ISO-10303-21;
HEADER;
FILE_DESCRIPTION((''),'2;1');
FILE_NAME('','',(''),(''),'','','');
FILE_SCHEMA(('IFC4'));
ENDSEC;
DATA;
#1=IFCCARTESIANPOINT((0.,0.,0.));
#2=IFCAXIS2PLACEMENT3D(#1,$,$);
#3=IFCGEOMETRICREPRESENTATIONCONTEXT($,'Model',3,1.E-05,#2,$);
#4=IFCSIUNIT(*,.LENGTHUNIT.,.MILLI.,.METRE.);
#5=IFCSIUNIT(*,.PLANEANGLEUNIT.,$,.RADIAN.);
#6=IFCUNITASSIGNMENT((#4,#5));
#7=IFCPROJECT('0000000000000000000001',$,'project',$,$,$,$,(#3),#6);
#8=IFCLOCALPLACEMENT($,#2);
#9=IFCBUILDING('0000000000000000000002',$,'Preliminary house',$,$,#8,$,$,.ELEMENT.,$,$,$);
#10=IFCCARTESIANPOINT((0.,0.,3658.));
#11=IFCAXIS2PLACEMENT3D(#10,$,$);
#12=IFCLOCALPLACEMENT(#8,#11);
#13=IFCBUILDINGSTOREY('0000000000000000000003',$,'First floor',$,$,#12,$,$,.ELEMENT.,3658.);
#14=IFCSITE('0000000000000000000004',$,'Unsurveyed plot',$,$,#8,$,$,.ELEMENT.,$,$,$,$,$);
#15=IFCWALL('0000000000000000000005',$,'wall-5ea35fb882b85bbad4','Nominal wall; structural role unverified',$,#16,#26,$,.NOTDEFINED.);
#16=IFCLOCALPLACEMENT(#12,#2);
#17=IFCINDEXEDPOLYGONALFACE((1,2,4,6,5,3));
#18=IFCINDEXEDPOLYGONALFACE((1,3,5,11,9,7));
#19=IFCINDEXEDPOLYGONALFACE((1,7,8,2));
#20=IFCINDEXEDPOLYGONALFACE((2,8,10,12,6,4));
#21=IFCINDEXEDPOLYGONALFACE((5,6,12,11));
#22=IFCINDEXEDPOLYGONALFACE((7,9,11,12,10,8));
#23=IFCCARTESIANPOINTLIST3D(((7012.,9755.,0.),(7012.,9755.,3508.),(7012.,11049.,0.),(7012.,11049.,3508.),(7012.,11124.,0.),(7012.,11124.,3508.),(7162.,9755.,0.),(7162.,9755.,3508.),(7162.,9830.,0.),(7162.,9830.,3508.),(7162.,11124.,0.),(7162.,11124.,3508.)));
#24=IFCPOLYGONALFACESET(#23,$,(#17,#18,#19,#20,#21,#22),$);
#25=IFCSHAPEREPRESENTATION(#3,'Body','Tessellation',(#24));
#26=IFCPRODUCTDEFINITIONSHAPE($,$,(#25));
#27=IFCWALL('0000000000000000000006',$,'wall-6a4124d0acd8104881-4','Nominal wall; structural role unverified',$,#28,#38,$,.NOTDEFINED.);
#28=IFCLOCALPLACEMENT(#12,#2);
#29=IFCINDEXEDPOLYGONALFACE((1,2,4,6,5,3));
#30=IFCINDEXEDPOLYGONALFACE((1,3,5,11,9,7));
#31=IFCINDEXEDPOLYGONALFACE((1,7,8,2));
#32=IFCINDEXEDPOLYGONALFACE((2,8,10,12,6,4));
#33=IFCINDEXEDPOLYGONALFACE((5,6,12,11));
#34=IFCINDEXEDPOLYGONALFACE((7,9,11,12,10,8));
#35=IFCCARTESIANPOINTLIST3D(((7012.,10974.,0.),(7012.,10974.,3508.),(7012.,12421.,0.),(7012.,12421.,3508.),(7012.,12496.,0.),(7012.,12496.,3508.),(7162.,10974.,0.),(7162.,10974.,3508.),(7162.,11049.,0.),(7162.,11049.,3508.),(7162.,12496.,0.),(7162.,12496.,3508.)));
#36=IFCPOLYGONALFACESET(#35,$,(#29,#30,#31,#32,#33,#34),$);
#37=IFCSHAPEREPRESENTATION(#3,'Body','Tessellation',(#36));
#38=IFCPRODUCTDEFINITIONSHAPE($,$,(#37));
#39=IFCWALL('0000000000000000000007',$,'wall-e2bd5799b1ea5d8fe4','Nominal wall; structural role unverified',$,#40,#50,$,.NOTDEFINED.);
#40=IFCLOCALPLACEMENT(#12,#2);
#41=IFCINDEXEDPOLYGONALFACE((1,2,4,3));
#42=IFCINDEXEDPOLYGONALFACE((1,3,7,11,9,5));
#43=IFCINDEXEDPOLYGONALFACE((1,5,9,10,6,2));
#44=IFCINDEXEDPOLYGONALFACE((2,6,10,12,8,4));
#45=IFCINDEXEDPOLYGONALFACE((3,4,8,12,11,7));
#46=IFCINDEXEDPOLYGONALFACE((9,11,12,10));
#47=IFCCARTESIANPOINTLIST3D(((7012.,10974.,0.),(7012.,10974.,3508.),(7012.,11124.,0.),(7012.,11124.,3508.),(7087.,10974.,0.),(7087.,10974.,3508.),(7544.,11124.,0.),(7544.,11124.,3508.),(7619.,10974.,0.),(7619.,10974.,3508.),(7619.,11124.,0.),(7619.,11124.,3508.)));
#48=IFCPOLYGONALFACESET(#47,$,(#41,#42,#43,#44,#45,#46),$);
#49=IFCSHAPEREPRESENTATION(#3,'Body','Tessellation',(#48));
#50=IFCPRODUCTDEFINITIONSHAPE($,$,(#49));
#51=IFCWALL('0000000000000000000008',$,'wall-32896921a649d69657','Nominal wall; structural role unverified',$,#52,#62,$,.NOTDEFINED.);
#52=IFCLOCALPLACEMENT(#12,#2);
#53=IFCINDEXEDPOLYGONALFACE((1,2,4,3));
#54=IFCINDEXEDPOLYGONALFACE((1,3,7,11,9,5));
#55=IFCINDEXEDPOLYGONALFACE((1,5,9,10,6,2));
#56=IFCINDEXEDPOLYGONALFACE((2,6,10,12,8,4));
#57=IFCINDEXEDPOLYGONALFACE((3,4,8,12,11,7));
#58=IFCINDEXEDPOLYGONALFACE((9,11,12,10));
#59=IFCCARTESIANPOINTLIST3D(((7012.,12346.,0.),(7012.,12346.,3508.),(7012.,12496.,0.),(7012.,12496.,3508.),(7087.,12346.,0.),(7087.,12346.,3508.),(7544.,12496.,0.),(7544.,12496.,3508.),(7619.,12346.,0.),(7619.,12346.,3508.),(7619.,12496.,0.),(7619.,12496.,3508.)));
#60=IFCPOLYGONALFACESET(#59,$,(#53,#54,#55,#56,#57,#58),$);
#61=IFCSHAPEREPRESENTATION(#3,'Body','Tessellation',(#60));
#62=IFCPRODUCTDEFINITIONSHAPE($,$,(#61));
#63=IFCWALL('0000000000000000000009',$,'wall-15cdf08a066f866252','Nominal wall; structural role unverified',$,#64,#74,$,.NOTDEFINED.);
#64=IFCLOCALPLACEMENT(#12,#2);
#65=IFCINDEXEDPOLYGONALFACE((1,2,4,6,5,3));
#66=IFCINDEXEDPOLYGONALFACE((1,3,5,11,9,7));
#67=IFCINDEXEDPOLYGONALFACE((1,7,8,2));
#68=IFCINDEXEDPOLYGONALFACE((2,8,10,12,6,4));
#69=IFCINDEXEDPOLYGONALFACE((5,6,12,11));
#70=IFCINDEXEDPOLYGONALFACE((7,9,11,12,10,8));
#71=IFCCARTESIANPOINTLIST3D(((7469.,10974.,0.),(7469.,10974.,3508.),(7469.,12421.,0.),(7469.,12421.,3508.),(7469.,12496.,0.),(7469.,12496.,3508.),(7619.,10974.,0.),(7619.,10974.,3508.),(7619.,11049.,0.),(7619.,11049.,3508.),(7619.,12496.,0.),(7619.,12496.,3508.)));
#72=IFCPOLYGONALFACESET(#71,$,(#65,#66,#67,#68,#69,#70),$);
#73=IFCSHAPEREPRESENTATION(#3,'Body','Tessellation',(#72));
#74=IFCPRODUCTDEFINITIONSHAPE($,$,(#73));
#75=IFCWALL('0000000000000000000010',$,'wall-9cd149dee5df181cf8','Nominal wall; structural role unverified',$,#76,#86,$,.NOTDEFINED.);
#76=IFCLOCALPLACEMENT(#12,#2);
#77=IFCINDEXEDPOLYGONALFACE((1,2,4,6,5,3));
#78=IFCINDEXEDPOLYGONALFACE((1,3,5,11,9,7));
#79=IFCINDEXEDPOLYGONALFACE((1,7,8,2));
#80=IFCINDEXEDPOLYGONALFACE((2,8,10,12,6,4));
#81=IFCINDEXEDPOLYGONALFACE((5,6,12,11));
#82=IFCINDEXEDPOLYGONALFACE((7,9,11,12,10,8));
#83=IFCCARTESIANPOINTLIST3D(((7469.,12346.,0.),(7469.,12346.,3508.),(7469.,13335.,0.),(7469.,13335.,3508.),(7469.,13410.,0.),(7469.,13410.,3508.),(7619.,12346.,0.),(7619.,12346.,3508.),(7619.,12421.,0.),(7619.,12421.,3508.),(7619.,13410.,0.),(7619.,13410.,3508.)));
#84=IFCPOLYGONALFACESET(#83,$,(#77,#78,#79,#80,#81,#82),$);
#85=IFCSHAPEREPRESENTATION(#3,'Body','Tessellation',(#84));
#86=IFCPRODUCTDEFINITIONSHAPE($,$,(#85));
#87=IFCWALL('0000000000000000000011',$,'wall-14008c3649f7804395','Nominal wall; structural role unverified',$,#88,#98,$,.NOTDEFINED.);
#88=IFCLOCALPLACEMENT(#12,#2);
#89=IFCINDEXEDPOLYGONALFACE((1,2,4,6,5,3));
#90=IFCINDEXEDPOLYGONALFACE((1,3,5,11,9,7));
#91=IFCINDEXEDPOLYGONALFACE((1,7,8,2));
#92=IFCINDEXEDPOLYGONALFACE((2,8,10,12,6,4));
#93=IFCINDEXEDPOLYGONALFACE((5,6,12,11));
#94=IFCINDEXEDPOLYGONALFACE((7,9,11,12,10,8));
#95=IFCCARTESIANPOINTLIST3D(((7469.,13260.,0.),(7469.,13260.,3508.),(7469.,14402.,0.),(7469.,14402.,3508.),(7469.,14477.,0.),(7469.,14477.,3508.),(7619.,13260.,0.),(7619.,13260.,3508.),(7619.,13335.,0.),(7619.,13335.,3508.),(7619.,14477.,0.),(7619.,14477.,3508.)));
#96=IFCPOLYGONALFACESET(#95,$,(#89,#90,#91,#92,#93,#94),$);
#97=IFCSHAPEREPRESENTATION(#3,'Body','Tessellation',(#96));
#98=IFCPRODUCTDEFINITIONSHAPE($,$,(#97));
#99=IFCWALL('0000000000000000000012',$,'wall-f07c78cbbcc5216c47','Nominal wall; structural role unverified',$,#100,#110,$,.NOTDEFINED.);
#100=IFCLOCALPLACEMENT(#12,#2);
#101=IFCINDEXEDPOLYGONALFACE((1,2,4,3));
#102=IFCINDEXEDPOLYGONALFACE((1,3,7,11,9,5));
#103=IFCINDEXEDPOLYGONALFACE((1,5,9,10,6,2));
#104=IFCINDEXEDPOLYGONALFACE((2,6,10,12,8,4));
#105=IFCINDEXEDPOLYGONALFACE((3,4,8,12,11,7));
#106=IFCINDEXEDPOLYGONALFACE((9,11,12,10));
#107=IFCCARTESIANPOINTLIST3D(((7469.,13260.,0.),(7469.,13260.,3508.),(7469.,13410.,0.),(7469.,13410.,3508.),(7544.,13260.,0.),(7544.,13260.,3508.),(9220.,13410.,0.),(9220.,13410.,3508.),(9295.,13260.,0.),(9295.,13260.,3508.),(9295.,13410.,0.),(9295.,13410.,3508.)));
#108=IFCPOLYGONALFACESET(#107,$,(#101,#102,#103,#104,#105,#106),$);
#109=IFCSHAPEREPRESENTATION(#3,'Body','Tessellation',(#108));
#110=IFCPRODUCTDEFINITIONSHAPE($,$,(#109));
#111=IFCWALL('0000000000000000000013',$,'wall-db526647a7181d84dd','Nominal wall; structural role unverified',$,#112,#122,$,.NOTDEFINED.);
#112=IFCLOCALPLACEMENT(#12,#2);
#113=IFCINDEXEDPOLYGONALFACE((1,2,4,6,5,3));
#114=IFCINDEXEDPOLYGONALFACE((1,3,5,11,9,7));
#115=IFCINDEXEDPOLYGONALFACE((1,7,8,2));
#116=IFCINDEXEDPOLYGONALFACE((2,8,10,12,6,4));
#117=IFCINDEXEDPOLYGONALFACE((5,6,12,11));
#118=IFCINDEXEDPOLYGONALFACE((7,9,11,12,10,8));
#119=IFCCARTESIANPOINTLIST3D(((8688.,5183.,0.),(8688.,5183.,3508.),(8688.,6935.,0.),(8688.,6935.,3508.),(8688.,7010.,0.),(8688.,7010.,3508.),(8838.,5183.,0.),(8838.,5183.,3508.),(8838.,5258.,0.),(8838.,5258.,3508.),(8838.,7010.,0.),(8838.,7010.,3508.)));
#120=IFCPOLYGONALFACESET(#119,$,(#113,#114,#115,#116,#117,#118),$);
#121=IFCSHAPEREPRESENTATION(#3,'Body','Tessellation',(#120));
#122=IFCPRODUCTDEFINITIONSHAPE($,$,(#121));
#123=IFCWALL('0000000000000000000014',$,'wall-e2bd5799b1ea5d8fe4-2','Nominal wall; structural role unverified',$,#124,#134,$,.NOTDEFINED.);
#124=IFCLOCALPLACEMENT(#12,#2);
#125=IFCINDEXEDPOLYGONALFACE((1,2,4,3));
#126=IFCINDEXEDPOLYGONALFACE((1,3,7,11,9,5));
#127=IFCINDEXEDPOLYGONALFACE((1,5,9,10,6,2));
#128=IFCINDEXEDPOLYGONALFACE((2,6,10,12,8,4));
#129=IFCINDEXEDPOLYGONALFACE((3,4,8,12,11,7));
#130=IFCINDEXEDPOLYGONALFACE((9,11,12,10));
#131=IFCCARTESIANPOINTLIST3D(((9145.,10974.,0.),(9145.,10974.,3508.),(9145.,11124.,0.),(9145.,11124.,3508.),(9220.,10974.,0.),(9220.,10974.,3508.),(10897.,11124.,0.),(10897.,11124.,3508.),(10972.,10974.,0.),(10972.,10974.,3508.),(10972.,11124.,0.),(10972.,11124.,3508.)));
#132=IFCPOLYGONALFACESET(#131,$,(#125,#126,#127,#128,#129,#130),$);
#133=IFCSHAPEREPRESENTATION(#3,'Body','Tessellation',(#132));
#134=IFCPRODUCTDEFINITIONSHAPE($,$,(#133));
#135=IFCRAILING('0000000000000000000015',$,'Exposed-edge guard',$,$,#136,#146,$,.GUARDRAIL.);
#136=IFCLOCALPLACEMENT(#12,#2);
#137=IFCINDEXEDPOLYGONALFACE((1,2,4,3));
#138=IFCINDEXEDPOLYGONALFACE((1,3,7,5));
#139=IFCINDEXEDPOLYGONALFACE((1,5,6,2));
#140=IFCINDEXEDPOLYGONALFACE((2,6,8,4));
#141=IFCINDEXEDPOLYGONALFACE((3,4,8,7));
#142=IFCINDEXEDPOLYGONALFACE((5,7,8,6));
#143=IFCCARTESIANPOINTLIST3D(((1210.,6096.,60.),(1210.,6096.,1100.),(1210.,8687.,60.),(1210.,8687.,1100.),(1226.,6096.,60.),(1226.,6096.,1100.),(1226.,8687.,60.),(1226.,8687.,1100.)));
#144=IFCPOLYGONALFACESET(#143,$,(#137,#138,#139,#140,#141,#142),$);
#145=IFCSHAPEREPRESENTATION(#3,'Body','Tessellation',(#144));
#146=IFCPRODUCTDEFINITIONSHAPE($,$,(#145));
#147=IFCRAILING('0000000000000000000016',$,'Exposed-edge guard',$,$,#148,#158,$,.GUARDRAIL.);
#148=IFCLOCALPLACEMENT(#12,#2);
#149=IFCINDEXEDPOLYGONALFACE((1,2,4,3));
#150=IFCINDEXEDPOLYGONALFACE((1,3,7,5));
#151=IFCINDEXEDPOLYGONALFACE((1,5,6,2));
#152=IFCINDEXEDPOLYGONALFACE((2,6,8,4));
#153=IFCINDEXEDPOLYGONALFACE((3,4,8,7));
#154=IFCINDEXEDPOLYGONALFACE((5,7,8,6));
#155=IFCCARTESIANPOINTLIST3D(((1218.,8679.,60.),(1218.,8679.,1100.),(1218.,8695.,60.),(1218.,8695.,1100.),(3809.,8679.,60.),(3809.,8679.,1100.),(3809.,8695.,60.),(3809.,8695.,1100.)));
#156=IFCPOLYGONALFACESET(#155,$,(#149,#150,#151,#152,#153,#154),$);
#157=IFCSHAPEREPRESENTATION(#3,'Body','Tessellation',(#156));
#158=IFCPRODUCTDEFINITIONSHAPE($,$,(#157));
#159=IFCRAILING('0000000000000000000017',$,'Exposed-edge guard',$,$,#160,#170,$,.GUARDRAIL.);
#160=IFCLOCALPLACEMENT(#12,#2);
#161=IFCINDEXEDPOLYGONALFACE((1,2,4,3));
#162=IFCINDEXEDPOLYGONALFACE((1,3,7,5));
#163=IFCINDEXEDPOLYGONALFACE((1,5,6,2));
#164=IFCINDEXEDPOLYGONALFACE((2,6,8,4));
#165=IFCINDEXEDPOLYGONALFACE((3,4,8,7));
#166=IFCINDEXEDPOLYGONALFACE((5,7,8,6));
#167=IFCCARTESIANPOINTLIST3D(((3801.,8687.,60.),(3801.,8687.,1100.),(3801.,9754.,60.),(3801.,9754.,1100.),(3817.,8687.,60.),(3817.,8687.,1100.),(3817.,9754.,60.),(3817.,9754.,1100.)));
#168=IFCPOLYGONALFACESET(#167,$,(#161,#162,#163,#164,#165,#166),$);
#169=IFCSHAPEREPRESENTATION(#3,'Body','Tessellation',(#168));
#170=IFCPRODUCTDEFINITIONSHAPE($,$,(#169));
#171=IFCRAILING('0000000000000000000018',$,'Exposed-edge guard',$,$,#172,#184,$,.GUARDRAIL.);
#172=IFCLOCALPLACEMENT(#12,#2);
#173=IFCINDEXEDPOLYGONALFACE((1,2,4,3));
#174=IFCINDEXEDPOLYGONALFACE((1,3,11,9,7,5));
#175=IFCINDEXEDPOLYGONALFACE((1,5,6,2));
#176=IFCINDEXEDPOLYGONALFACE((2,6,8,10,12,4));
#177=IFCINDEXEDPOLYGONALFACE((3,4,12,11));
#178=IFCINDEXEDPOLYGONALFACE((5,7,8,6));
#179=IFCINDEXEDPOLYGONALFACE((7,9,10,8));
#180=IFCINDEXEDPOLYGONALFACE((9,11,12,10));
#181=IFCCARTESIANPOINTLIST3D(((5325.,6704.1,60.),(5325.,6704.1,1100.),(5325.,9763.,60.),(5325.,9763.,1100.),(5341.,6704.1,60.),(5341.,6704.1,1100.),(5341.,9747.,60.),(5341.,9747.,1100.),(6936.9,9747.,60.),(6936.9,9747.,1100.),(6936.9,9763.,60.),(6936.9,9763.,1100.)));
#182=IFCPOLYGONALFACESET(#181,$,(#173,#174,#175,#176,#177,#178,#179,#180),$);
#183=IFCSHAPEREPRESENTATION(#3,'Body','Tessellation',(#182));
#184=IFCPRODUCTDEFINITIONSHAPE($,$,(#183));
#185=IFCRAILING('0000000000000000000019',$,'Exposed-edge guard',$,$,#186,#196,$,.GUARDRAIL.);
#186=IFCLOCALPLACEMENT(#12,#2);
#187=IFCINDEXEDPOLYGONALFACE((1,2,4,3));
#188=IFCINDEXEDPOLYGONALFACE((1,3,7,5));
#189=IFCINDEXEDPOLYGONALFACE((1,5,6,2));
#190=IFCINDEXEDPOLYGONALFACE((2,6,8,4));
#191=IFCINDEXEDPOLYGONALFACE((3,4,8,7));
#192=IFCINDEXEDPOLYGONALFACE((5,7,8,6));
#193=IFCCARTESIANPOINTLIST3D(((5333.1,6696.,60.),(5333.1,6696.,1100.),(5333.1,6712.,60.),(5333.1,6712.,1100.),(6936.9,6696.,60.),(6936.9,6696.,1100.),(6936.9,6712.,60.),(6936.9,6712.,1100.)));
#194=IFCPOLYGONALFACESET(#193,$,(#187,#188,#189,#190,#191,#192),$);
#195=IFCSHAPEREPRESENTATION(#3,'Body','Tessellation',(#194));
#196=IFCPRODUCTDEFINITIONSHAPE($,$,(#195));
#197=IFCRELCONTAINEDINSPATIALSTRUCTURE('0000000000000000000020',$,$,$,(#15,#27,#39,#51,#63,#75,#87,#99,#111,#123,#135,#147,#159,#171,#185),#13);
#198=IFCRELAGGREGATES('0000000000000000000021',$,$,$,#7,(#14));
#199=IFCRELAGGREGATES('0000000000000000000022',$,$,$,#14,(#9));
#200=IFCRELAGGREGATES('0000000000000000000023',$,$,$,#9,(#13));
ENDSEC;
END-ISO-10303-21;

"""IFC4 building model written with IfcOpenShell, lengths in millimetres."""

from ifc_helpers import new_model, si_unit, frame, origin, place, context, project, spatial, polyline, outline, extrude, element, save


model = new_model("IFC4")

# Units and contexts
model_context = context("Model", 3, precision=1e-05, world=origin())
ifc_project = project(units=[si_unit("LENGTHUNIT", "METRE", prefix="MILLI"), si_unit("PLANEANGLEUNIT", "RADIAN")], contexts=[model_context])

# Site, building, storey
placement_1 = place(None, origin())
site = spatial("IfcSite", under=ifc_project, at=placement_1, Name="Unsurveyed plot", CompositionType="ELEMENT")
building = spatial("IfcBuilding", under=site, at=placement_1, Name="Preliminary house", CompositionType="ELEMENT")
placement_2 = place(placement_1, frame((0.0, 0.0, 3658.0)))
storey = spatial("IfcBuildingStorey", under=building, at=placement_2, Name="First floor", CompositionType="ELEMENT", Elevation=3658.0)

# Walls
element("IfcWall", 1, at=placement_2, inside=storey, Name="wall-5ea35fb882b85bbad4", Description="Nominal wall; structural role unverified", PredefinedType="NOTDEFINED", context=model_context, shape_type="SweptSolid", body=[
    extrude(outline(polyline([(7012.0, 11049.0), (7012.0, 11124.0), (7162.0, 11124.0), (7162.0, 9830.0), (7162.0, 9755.0), (7012.0, 9755.0), (7012.0, 11049.0)])), origin(), (0.0, 0.0, 1.0), 3508.0),
])
element("IfcWall", 2, at=placement_2, inside=storey, Name="wall-6a4124d0acd8104881-4", Description="Nominal wall; structural role unverified", PredefinedType="NOTDEFINED", context=model_context, shape_type="SweptSolid", body=[
    extrude(outline(polyline([(7012.0, 12421.0), (7012.0, 12496.0), (7162.0, 12496.0), (7162.0, 11049.0), (7162.0, 10974.0), (7012.0, 10974.0), (7012.0, 12421.0)])), origin(), (0.0, 0.0, 1.0), 3508.0),
])
element("IfcWall", 3, at=placement_2, inside=storey, Name="wall-e2bd5799b1ea5d8fe4", Description="Nominal wall; structural role unverified", PredefinedType="NOTDEFINED", context=model_context, shape_type="SweptSolid", body=[
    extrude(outline(polyline([(7544.0, 11124.0), (7619.0, 11124.0), (7619.0, 10974.0), (7087.0, 10974.0), (7012.0, 10974.0), (7012.0, 11124.0), (7544.0, 11124.0)])), origin(), (0.0, 0.0, 1.0), 3508.0),
])
element("IfcWall", 4, at=placement_2, inside=storey, Name="wall-32896921a649d69657", Description="Nominal wall; structural role unverified", PredefinedType="NOTDEFINED", context=model_context, shape_type="SweptSolid", body=[
    extrude(outline(polyline([(7544.0, 12496.0), (7619.0, 12496.0), (7619.0, 12346.0), (7087.0, 12346.0), (7012.0, 12346.0), (7012.0, 12496.0), (7544.0, 12496.0)])), origin(), (0.0, 0.0, 1.0), 3508.0),
])
element("IfcWall", 5, at=placement_2, inside=storey, Name="wall-15cdf08a066f866252", Description="Nominal wall; structural role unverified", PredefinedType="NOTDEFINED", context=model_context, shape_type="SweptSolid", body=[
    extrude(outline(polyline([(7469.0, 12421.0), (7469.0, 12496.0), (7619.0, 12496.0), (7619.0, 11049.0), (7619.0, 10974.0), (7469.0, 10974.0), (7469.0, 12421.0)])), origin(), (0.0, 0.0, 1.0), 3508.0),
])

# Walls
element("IfcWall", 6, at=placement_2, inside=storey, Name="wall-9cd149dee5df181cf8", Description="Nominal wall; structural role unverified", PredefinedType="NOTDEFINED", context=model_context, shape_type="SweptSolid", body=[
    extrude(outline(polyline([(7469.0, 13335.0), (7469.0, 13410.0), (7619.0, 13410.0), (7619.0, 12421.0), (7619.0, 12346.0), (7469.0, 12346.0), (7469.0, 13335.0)])), origin(), (0.0, 0.0, 1.0), 3508.0),
])
element("IfcWall", 7, at=placement_2, inside=storey, Name="wall-14008c3649f7804395", Description="Nominal wall; structural role unverified", PredefinedType="NOTDEFINED", context=model_context, shape_type="SweptSolid", body=[
    extrude(outline(polyline([(7469.0, 14402.0), (7469.0, 14477.0), (7619.0, 14477.0), (7619.0, 13335.0), (7619.0, 13260.0), (7469.0, 13260.0), (7469.0, 14402.0)])), origin(), (0.0, 0.0, 1.0), 3508.0),
])
element("IfcWall", 8, at=placement_2, inside=storey, Name="wall-f07c78cbbcc5216c47", Description="Nominal wall; structural role unverified", PredefinedType="NOTDEFINED", context=model_context, shape_type="SweptSolid", body=[
    extrude(outline(polyline([(9220.0, 13410.0), (9295.0, 13410.0), (9295.0, 13260.0), (7544.0, 13260.0), (7469.0, 13260.0), (7469.0, 13410.0), (9220.0, 13410.0)])), origin(), (0.0, 0.0, 1.0), 3508.0),
])
element("IfcWall", 9, at=placement_2, inside=storey, Name="wall-db526647a7181d84dd", Description="Nominal wall; structural role unverified", PredefinedType="NOTDEFINED", context=model_context, shape_type="SweptSolid", body=[
    extrude(outline(polyline([(8688.0, 6935.0), (8688.0, 7010.0), (8838.0, 7010.0), (8838.0, 5258.0), (8838.0, 5183.0), (8688.0, 5183.0), (8688.0, 6935.0)])), origin(), (0.0, 0.0, 1.0), 3508.0),
])

# Wall
element("IfcWall", 10, at=placement_2, inside=storey, Name="wall-e2bd5799b1ea5d8fe4-2", Description="Nominal wall; structural role unverified", PredefinedType="NOTDEFINED", context=model_context, shape_type="SweptSolid", body=[
    extrude(outline(polyline([(10897.0, 11124.0), (10972.0, 11124.0), (10972.0, 10974.0), (9220.0, 10974.0), (9145.0, 10974.0), (9145.0, 11124.0), (10897.0, 11124.0)])), origin(), (0.0, 0.0, 1.0), 3508.0),
])

# Railings
element("IfcRailing", 11, at=placement_2, inside=storey, Name="Exposed-edge guard", PredefinedType="GUARDRAIL", context=model_context, shape_type="SweptSolid", body=[
    extrude(outline(polyline([(1210.0, 8687.0), (1226.0, 8687.0), (1226.0, 6096.0), (1210.0, 6096.0), (1210.0, 8687.0)])), frame((0.0, 0.0, 60.0)), (0.0, 0.0, 1.0), 1040.0),
])
element("IfcRailing", 12, at=placement_2, inside=storey, Name="Exposed-edge guard", PredefinedType="GUARDRAIL", context=model_context, shape_type="SweptSolid", body=[
    extrude(outline(polyline([(3809.0, 8695.0), (3809.0, 8679.0), (1218.0, 8679.0), (1218.0, 8695.0), (3809.0, 8695.0)])), frame((0.0, 0.0, 60.0)), (0.0, 0.0, 1.0), 1040.0),
])
element("IfcRailing", 13, at=placement_2, inside=storey, Name="Exposed-edge guard", PredefinedType="GUARDRAIL", context=model_context, shape_type="SweptSolid", body=[
    extrude(outline(polyline([(3801.0, 9754.0), (3817.0, 9754.0), (3817.0, 8687.0), (3801.0, 8687.0), (3801.0, 9754.0)])), frame((0.0, 0.0, 60.0)), (0.0, 0.0, 1.0), 1040.0),
])
element("IfcRailing", 14, at=placement_2, inside=storey, Name="Exposed-edge guard", PredefinedType="GUARDRAIL", context=model_context, shape_type="SweptSolid", body=[
    extrude(outline(polyline([(5341.0, 9747.0), (5341.0, 6704.1), (5325.0, 6704.1), (5325.0, 9763.0), (6936.9, 9763.0), (6936.9, 9747.0), (5341.0, 9747.0)])), frame((0.0, 0.0, 60.0)), (0.0, 0.0, 1.0), 1040.0),
])
element("IfcRailing", 15, at=placement_2, inside=storey, Name="Exposed-edge guard", PredefinedType="GUARDRAIL", context=model_context, shape_type="SweptSolid", body=[
    extrude(outline(polyline([(6936.9, 6712.0), (6936.9, 6696.0), (5333.1, 6696.0), (5333.1, 6712.0), (6936.9, 6712.0)])), frame((0.0, 0.0, 60.0)), (0.0, 0.0, 1.0), 1040.0),
])

save(model, "model.ifc")
